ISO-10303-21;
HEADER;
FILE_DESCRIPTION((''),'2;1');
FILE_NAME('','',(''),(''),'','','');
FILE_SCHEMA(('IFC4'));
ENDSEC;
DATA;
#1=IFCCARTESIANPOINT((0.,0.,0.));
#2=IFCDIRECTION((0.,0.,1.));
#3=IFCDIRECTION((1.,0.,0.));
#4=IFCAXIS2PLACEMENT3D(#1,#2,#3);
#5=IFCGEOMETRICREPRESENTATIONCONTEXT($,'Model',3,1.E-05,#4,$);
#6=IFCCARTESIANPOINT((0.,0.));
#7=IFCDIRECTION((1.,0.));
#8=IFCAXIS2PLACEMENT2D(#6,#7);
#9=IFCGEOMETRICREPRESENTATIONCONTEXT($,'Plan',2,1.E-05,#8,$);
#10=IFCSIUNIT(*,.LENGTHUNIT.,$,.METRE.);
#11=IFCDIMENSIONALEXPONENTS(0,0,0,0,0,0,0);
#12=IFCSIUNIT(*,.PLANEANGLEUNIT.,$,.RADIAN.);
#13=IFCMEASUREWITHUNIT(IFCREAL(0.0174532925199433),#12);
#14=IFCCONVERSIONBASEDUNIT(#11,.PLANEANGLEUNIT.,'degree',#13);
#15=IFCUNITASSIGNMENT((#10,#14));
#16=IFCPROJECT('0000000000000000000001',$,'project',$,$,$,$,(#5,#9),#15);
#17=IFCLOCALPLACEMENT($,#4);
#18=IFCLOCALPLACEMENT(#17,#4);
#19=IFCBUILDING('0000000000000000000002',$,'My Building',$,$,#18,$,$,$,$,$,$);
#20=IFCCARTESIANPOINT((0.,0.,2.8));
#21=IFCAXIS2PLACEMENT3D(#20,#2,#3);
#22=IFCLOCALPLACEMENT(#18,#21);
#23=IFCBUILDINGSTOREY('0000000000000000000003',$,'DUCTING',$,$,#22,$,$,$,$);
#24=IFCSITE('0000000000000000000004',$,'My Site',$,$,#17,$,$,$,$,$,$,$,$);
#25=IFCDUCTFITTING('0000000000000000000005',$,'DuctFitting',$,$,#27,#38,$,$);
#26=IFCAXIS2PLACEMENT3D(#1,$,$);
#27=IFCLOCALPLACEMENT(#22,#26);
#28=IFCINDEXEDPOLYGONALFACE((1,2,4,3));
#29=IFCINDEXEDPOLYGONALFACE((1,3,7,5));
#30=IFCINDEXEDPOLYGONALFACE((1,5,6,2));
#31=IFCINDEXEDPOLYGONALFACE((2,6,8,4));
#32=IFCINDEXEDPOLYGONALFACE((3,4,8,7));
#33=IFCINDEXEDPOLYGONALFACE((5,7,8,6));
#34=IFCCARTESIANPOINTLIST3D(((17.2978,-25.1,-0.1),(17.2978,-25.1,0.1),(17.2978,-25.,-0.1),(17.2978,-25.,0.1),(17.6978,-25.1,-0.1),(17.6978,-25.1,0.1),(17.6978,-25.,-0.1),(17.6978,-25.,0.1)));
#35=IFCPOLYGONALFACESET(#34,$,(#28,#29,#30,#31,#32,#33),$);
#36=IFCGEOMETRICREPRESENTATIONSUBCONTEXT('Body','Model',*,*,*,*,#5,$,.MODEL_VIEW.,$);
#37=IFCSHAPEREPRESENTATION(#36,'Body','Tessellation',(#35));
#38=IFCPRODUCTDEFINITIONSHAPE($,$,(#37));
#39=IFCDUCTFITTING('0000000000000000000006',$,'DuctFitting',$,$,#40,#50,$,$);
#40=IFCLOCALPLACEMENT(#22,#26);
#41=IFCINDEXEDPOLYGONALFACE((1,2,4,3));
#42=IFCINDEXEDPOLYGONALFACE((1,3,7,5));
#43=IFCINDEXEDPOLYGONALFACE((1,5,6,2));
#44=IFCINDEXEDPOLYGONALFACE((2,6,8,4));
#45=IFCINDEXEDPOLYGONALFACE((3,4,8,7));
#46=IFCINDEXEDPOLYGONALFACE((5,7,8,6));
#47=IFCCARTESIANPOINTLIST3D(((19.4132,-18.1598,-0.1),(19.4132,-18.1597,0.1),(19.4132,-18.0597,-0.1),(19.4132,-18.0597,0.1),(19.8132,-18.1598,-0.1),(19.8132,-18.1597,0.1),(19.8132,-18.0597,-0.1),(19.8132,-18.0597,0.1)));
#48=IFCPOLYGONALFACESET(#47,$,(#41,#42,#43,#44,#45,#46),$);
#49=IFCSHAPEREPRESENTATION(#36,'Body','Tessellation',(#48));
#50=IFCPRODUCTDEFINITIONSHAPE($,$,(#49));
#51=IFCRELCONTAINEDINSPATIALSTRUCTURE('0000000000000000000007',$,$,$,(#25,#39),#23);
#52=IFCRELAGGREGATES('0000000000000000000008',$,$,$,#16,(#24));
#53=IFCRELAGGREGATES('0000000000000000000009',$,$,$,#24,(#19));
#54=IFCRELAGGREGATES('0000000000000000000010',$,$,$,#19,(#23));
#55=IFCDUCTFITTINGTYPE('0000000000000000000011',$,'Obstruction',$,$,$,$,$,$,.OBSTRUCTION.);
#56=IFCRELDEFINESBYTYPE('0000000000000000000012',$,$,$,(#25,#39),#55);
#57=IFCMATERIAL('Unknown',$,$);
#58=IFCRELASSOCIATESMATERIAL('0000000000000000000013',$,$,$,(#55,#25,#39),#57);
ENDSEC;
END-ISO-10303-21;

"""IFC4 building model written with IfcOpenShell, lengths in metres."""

from ifc_helpers import new_model, entity, si_unit, converted_unit, frame, origin_with_axes, origin_2d_with_axis, place, context, subcontext, project, spatial, rectangle, extrude, material, material_profile, profile_set, profile_usage, type_object, element, save


model = new_model("IFC4")

# Units and contexts
model_context = context("Model", 3, precision=1e-05, world=origin_with_axes())
plan_context = context("Plan", 2, precision=1e-05, world=origin_2d_with_axis())
body_context = subcontext(model_context, "Body", "Model", "MODEL_VIEW")
ifc_project = project(units=[si_unit("LENGTHUNIT", "METRE"), converted_unit("PLANEANGLEUNIT", "degree", entity("IfcReal", 0.0174532925199433), si_unit("PLANEANGLEUNIT", "RADIAN"), dimensions=[0, 0, 0, 0, 0, 0, 0])], contexts=[model_context, plan_context])

# Site, building, storey
site_placement = place(None, origin_with_axes())
site = spatial("IfcSite", under=ifc_project, at=site_placement, Name="My Site")
building_placement = place(site_placement, origin_with_axes())
building = spatial("IfcBuilding", under=site, at=building_placement, Name="My Building")
storey_placement = place(building_placement, frame((0.0, 0.0, 2.8), z_axis=(0.0, 0.0, 1.0), x_axis=(1.0, 0.0, 0.0)))
storey = spatial("IfcBuildingStorey", under=building, at=storey_placement, Name="DUCTING")

# Shared definitions
ifc_material = material(Name="Unknown")

# Duct fittings
ifc_material_profile_1 = material_profile(ifc_material, rectangle(XDim=0.4, YDim=0.2))
ifc_profile_set_1 = profile_set([ifc_material_profile_1])
duct_fitting_type_1 = type_object("IfcDuctFittingType", Name="Obstruction", PredefinedType="OBSTRUCTION", material=ifc_profile_set_1)
ifc_profile_usage_1 = profile_usage(ifc_profile_set_1, cardinal=5)
duct_fitting_1_placement = place(storey_placement, frame((17.4978, -25.0, 0.0), z_axis=(0.0, -1.0, 0.0), x_axis=(1.0, 0.0, 0.0)))
element("IfcDuctFitting", 1, at=duct_fitting_1_placement, inside=storey, type_object=duct_fitting_type_1, material=ifc_profile_usage_1, Name="DuctFitting", context=body_context, shape_type="SweptSolid", body=[
    extrude(rectangle(XDim=0.4, YDim=0.2), origin_with_axes(), (0.0, 0.0, 1.0), 0.1),
])
ifc_profile_usage_2 = profile_usage(ifc_profile_set_1, cardinal=5)
duct_fitting_2_placement = place(storey_placement, frame((19.6132, -18.0597, 0.0), z_axis=(0.0, -1.0, 0.0), x_axis=(1.0, 0.0, 0.0)))
element("IfcDuctFitting", 2, at=duct_fitting_2_placement, inside=storey, type_object=duct_fitting_type_1, material=ifc_profile_usage_2, Name="DuctFitting", context=body_context, shape_type="SweptSolid", body=[
    extrude(rectangle(XDim=0.4, YDim=0.2), origin_with_axes(), (0.0, 0.0, 1.0), 0.1),
])

save(model, "model.ifc")
